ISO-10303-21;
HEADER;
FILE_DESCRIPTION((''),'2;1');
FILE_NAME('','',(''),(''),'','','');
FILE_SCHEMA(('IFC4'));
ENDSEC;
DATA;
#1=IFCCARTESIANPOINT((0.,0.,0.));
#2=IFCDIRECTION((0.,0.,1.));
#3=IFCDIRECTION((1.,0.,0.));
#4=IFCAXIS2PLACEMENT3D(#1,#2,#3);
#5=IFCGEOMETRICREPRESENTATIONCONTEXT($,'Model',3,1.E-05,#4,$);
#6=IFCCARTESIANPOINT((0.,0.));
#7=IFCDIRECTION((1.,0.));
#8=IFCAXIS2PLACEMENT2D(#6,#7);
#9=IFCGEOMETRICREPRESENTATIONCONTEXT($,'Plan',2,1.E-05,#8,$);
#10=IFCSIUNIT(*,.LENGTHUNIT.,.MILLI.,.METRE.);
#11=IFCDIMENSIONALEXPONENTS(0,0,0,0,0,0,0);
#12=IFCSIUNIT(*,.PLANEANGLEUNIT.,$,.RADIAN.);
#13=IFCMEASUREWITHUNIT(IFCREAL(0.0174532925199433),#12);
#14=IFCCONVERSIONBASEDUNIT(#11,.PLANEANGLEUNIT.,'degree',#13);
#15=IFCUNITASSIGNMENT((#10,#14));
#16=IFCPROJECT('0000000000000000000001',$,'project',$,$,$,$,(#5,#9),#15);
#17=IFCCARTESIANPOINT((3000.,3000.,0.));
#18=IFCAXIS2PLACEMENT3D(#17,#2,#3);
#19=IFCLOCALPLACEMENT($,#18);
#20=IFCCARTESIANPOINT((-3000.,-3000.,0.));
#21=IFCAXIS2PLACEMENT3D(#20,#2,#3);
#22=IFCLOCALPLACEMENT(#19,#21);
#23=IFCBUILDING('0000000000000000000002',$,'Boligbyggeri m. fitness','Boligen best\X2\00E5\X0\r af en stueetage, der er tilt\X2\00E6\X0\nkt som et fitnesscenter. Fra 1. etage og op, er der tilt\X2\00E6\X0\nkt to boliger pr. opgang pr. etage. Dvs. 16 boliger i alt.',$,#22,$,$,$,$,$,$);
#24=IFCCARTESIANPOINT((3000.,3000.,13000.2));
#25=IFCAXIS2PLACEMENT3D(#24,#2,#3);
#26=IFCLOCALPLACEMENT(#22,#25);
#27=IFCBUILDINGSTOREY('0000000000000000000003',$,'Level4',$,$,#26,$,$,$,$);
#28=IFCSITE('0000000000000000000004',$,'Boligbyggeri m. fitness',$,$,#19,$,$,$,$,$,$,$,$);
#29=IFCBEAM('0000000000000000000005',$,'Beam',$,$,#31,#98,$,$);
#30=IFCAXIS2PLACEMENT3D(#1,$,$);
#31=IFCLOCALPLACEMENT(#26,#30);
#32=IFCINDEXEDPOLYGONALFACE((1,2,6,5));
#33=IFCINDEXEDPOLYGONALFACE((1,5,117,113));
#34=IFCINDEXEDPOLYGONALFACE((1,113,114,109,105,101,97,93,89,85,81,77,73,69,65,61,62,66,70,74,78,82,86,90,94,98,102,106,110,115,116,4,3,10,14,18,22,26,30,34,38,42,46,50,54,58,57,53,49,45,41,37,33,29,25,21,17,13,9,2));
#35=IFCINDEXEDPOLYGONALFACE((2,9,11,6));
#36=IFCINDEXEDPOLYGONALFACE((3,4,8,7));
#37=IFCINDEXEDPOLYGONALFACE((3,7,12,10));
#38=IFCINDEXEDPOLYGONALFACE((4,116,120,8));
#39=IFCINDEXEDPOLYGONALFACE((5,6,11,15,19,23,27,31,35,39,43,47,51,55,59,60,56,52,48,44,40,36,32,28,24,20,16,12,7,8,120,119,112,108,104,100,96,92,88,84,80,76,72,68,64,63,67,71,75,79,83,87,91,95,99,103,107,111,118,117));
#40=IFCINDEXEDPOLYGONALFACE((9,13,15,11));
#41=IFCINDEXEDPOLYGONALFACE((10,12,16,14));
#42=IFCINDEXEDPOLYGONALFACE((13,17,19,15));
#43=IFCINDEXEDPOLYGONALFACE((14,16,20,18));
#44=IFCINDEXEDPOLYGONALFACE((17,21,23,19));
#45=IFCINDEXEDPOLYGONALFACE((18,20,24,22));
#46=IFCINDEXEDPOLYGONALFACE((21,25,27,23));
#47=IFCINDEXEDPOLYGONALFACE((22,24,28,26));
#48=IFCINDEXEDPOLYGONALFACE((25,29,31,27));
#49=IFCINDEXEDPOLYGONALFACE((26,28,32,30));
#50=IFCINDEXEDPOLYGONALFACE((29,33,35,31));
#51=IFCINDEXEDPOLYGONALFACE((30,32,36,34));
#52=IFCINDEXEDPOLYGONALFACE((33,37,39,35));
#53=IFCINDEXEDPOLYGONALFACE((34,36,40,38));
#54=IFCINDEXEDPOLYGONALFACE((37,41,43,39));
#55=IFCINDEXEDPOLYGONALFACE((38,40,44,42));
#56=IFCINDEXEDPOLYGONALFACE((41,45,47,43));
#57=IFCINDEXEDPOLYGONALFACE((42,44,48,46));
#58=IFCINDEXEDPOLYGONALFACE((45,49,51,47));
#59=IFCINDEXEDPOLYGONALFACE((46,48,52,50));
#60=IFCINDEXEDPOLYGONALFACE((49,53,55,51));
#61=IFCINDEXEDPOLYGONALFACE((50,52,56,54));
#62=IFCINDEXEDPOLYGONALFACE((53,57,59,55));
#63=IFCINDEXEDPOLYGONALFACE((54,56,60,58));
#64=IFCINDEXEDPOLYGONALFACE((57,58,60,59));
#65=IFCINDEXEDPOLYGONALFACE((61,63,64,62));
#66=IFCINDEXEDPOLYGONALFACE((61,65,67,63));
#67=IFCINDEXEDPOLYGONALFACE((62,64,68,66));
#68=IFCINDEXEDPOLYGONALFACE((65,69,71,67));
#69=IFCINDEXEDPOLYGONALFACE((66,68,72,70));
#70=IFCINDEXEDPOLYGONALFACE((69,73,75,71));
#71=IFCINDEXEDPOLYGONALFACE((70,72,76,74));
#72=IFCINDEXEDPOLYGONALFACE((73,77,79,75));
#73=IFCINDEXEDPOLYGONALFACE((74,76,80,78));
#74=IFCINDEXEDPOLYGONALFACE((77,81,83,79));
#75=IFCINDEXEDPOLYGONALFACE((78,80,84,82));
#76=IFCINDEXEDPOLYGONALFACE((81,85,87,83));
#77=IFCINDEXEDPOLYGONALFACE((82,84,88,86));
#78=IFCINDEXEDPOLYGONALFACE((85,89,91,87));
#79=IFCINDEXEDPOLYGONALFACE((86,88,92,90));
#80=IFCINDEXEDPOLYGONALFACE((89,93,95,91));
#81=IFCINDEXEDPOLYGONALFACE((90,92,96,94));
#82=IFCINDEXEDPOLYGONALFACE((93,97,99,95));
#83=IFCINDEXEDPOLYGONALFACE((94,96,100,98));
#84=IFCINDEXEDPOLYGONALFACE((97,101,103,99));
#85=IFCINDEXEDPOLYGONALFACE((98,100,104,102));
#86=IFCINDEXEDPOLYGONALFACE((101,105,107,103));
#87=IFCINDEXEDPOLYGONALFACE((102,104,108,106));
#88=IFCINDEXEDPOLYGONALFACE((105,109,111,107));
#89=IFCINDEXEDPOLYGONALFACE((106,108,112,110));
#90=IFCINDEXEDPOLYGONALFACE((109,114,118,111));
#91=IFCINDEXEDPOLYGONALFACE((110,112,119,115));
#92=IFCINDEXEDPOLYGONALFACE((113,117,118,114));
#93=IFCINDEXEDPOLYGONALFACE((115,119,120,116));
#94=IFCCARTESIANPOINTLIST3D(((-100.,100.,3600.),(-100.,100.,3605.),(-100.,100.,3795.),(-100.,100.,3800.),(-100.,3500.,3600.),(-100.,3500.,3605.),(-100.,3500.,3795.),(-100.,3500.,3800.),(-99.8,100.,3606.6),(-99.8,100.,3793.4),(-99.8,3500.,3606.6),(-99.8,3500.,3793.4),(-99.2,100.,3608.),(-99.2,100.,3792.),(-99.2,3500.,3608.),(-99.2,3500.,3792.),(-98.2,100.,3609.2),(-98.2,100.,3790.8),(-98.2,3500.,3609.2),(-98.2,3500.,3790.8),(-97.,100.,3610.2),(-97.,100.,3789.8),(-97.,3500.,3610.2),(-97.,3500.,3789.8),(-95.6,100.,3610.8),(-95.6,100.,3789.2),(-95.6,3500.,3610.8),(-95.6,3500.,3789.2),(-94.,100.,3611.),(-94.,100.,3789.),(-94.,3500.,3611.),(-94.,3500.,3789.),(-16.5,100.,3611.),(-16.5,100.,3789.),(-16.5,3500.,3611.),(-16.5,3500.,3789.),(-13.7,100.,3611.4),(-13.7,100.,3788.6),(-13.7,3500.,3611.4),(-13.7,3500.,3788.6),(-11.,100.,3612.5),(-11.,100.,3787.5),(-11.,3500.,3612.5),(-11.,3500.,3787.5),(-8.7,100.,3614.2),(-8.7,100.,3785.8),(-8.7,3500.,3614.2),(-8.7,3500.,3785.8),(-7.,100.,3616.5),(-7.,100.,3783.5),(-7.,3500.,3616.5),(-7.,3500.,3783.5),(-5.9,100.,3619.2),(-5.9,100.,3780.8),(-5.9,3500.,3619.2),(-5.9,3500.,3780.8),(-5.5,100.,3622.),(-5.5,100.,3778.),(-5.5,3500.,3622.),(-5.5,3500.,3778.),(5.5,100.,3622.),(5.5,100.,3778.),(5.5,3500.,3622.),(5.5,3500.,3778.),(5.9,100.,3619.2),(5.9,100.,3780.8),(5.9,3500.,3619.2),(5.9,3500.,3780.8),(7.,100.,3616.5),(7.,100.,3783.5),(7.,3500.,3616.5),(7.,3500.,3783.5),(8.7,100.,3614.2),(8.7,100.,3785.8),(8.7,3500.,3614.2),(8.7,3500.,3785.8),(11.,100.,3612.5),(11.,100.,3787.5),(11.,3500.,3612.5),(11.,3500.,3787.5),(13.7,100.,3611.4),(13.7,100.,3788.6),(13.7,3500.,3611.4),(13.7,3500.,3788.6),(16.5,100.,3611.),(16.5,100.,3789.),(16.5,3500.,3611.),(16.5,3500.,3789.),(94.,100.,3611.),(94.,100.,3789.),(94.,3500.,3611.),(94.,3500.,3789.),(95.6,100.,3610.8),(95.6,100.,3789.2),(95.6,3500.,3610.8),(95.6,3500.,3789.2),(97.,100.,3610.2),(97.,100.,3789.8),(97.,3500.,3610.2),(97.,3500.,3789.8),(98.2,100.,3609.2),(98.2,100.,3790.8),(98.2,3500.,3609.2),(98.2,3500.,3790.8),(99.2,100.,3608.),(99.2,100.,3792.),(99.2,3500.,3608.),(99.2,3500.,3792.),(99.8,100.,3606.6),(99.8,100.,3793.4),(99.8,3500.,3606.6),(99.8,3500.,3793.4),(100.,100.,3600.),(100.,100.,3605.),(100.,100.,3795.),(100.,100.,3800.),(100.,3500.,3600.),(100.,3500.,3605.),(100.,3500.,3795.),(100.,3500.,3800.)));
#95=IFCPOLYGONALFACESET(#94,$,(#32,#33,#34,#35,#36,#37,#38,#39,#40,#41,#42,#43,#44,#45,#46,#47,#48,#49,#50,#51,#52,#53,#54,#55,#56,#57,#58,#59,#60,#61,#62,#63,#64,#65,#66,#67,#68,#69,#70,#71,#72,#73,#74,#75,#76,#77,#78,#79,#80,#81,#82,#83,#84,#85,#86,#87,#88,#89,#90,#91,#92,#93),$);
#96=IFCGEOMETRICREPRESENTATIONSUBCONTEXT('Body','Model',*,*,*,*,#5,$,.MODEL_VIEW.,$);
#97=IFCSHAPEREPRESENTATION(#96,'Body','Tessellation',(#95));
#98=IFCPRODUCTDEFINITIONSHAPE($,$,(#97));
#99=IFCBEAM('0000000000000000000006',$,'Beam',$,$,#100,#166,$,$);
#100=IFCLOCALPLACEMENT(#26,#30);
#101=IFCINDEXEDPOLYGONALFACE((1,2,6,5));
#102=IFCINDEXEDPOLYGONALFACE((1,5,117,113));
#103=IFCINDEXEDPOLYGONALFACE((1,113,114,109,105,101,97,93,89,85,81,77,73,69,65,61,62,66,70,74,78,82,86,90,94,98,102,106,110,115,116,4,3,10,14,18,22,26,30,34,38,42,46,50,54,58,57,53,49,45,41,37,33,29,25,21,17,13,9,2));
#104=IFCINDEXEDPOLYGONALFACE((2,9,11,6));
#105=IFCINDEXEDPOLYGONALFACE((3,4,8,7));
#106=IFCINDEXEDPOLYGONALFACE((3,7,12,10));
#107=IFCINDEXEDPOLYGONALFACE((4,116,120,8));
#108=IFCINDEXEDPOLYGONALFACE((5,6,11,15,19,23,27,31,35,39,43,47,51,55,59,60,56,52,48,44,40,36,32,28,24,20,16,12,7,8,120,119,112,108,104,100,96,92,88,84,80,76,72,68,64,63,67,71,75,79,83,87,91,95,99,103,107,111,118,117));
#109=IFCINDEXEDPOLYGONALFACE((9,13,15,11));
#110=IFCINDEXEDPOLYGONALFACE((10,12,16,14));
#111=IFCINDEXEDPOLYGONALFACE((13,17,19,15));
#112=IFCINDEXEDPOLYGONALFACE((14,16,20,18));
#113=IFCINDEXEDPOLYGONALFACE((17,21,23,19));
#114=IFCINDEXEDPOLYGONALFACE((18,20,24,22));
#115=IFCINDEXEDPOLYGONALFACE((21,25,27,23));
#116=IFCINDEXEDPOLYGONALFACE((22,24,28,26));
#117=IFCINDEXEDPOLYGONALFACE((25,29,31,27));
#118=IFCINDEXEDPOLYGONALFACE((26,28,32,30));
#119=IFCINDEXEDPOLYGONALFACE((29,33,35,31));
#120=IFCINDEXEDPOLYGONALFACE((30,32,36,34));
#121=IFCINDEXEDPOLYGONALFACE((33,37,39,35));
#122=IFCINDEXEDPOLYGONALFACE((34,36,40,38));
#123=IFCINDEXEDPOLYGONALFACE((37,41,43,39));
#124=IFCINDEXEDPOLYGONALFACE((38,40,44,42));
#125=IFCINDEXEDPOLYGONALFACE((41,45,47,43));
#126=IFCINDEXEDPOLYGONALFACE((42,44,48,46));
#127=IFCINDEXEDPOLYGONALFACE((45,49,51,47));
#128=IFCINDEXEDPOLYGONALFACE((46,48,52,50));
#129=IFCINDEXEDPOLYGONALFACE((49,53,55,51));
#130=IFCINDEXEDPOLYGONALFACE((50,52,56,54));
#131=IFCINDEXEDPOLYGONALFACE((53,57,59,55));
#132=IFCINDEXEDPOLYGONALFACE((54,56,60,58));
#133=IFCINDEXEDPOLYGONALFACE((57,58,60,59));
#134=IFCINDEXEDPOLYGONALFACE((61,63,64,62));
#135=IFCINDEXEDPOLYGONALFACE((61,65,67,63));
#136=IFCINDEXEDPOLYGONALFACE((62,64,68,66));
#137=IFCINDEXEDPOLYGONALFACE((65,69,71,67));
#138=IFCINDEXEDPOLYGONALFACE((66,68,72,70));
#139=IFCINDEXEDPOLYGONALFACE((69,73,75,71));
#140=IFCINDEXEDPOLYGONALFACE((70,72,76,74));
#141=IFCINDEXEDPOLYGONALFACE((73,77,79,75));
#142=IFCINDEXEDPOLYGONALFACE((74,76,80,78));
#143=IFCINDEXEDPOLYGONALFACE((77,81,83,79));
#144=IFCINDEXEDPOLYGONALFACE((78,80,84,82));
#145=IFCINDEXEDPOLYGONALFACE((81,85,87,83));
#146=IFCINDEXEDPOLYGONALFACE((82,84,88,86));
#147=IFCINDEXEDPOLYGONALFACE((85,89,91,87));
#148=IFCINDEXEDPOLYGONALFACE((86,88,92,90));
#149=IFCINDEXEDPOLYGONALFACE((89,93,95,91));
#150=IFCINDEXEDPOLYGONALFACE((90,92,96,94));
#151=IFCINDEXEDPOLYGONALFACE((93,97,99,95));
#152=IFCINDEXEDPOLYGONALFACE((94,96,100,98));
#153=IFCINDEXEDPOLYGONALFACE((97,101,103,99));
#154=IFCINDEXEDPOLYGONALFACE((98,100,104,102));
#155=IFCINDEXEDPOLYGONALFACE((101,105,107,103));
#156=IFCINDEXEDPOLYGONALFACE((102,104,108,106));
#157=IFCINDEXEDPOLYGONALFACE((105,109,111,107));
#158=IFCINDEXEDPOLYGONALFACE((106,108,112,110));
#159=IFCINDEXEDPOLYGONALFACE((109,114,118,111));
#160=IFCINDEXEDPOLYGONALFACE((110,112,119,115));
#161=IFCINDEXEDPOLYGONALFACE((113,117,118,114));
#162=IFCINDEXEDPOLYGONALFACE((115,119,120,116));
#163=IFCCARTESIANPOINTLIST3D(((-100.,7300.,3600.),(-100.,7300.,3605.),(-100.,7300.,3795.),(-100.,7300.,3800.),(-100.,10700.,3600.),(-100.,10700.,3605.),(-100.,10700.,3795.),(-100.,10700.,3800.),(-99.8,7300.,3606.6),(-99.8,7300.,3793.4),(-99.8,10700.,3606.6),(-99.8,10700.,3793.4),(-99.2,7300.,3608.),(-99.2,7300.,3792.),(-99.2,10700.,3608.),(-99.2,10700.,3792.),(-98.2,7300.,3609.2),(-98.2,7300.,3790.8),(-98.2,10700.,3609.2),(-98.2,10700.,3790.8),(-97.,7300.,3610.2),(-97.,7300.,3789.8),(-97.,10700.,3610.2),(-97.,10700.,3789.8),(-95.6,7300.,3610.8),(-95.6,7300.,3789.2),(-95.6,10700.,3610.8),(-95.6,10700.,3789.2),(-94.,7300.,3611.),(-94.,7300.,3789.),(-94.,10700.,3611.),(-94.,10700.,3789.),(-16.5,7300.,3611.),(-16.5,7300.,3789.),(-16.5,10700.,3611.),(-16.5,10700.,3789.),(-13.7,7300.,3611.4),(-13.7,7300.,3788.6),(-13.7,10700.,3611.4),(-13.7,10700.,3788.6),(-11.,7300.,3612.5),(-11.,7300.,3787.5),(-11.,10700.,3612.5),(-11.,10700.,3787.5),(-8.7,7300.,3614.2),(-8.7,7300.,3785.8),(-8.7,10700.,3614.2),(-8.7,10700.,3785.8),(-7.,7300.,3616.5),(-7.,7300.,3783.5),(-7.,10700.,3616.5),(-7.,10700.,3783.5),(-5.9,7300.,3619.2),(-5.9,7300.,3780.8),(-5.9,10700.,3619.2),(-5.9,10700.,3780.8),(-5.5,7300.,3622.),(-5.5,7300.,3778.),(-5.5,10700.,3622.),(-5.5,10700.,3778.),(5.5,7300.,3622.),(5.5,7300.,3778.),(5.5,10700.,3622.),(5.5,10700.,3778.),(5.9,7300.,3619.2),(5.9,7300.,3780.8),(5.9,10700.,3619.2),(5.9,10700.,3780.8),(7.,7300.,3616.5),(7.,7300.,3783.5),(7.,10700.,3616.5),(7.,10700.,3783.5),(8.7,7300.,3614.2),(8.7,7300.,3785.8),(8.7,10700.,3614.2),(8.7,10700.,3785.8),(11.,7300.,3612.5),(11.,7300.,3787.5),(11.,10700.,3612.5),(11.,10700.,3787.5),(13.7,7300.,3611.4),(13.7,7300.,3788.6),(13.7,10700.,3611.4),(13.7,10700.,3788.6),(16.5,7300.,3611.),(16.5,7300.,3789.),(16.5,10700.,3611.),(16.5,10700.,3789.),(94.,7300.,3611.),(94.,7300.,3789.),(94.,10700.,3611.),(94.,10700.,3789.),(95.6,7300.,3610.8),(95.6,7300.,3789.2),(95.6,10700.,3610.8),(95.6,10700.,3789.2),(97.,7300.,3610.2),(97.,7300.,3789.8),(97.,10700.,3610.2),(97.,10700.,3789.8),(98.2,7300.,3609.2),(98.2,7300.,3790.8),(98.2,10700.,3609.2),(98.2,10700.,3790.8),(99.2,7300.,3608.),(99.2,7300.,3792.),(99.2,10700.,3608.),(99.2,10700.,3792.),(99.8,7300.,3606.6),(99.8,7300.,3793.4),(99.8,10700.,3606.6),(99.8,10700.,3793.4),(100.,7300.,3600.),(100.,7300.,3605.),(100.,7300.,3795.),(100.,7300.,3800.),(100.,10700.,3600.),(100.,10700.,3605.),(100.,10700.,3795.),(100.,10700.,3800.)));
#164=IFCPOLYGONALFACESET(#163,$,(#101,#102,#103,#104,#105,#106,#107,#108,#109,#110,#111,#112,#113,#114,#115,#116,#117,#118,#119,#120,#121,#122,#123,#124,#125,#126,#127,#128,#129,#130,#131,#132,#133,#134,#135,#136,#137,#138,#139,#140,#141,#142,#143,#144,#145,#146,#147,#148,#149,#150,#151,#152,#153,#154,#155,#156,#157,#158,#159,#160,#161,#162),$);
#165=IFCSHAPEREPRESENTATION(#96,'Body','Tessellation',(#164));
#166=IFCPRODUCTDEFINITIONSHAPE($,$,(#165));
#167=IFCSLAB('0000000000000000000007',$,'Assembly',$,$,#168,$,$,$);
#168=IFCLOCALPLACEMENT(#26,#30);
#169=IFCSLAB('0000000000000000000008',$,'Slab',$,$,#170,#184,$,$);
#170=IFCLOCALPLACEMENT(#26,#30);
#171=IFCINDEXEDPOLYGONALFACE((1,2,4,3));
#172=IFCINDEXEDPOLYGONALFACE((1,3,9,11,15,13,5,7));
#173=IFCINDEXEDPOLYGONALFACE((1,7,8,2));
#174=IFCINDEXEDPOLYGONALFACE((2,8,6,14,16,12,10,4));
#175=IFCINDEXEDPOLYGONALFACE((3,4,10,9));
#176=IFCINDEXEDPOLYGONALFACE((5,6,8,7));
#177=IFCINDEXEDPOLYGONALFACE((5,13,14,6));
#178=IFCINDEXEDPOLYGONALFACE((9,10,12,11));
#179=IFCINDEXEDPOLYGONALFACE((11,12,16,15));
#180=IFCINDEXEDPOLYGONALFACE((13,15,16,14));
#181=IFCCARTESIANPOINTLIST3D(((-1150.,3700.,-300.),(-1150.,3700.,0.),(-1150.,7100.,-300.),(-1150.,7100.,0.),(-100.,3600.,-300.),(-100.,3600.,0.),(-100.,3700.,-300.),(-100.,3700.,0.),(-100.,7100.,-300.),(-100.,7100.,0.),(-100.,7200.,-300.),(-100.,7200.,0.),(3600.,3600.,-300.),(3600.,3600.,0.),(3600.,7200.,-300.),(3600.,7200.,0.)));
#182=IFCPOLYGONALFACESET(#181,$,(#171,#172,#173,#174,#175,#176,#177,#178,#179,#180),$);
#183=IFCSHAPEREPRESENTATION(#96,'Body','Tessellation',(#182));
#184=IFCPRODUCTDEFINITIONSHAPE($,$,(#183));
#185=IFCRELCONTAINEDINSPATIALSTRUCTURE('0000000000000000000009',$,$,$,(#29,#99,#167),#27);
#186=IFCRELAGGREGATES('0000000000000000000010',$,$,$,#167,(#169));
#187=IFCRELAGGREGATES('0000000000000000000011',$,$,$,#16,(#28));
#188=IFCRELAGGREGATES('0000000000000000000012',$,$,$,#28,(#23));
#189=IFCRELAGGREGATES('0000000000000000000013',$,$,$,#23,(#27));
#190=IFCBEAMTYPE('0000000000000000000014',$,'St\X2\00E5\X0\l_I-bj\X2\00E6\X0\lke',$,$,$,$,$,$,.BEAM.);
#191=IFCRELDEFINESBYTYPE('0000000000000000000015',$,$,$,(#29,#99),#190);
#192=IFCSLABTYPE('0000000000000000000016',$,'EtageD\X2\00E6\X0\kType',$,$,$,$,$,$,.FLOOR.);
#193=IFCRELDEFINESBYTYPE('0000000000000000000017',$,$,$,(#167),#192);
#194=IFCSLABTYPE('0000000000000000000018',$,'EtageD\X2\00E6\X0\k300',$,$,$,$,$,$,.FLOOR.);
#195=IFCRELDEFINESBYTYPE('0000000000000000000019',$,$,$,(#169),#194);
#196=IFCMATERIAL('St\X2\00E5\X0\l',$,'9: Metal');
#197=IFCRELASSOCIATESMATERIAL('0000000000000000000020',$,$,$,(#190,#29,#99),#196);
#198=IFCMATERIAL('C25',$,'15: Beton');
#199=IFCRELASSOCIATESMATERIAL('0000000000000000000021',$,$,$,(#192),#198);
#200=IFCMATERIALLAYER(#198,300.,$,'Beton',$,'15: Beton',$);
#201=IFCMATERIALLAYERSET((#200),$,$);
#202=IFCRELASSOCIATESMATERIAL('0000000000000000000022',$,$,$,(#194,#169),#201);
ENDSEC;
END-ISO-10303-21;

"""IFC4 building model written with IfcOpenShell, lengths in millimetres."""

from ifc_helpers import new_model, entity, si_unit, converted_unit, frame, origin_with_axes, origin_2d_with_axis, place, context, subcontext, project, spatial, line, indexed_curve, i_section, outline, extrude, material, layer, layer_set, layer_usage, material_profile, profile_set, profile_usage, type_object, element, aggregate, save


model = new_model("IFC4")

# Units and contexts
model_context = context("Model", 3, precision=1e-05, world=origin_with_axes())
plan_context = context("Plan", 2, precision=1e-05, world=origin_2d_with_axis())
body_context = subcontext(model_context, "Body", "Model", "MODEL_VIEW")
ifc_project = project(units=[si_unit("LENGTHUNIT", "METRE", prefix="MILLI"), converted_unit("PLANEANGLEUNIT", "degree", entity("IfcReal", 0.0174532925199433), si_unit("PLANEANGLEUNIT", "RADIAN"), dimensions=[0, 0, 0, 0, 0, 0, 0])], contexts=[model_context, plan_context])

# Site, building, storey
site_placement = place(None, frame((3000.0, 3000.0, 0.0), z_axis=(0.0, 0.0, 1.0), x_axis=(1.0, 0.0, 0.0)))
site = spatial("IfcSite", under=ifc_project, at=site_placement, Name="Boligbyggeri m. fitness")
building_placement = place(site_placement, frame((-3000.0, -3000.0, 0.0), z_axis=(0.0, 0.0, 1.0), x_axis=(1.0, 0.0, 0.0)))
building = spatial("IfcBuilding", under=site, at=building_placement, Name="Boligbyggeri m. fitness", Description="Boligen består af en stueetage, der er tiltænkt som et fitnesscenter. Fra 1. etage og op, er der tiltænkt to boliger pr. opgang pr. etage. Dvs. 16 boliger i alt.")
storey_placement = place(building_placement, frame((3000.0, 3000.0, 13000.2), z_axis=(0.0, 0.0, 1.0), x_axis=(1.0, 0.0, 0.0)))
storey = spatial("IfcBuildingStorey", under=building, at=storey_placement, Name="Level4")

# Shared definitions
ifc_material_1 = material(Name="C25", Category="15: Beton")

# Beams
ifc_material_2 = material(Name="Stål", Category="9: Metal")
ifc_material_profile_1 = material_profile(ifc_material_2, i_section(OverallWidth=200.0, OverallDepth=200.0, WebThickness=11.0, FlangeThickness=11.0, FilletRadius=11.0, FlangeEdgeRadius=6.0), Name="Stål", Category="9: Metal")
ifc_profile_set_1 = profile_set([ifc_material_profile_1], Name="NY_I-Profil")
beam_type = type_object("IfcBeamType", Name="Stål_I-bjælke", PredefinedType="BEAM", material=ifc_profile_set_1)
ifc_profile_usage_1 = profile_usage(ifc_profile_set_1, cardinal=9)
beam_1_placement = place(storey_placement, frame((100.0, 100.0, 3800.0), z_axis=(0.0, 1.0, 0.0), x_axis=(-1.0, 0.0, 0.0)))
element("IfcBeam", 1, at=beam_1_placement, inside=storey, type_object=beam_type, material=ifc_profile_usage_1, Name="Beam", context=body_context, shape_type="SweptSolid", body=[
    extrude(i_section(OverallWidth=200.0, OverallDepth=200.0, WebThickness=11.0, FlangeThickness=11.0, FilletRadius=11.0, FlangeEdgeRadius=6.0), frame((100.0, -100.0, 0.0), z_axis=(0.0, 0.0, 1.0), x_axis=(1.0, 0.0, 0.0)), (0.0, 0.0, 1.0), 3400.0),
])
ifc_profile_usage_2 = profile_usage(ifc_profile_set_1, cardinal=9)
beam_2_placement = place(storey_placement, frame((100.0, 7300.0, 3800.0), z_axis=(0.0, 1.0, 0.0), x_axis=(-1.0, 0.0, 0.0)))
element("IfcBeam", 2, at=beam_2_placement, inside=storey, type_object=beam_type, material=ifc_profile_usage_2, Name="Beam", context=body_context, shape_type="SweptSolid", body=[
    extrude(i_section(OverallWidth=200.0, OverallDepth=200.0, WebThickness=11.0, FlangeThickness=11.0, FilletRadius=11.0, FlangeEdgeRadius=6.0), frame((100.0, -100.0, 0.0), z_axis=(0.0, 0.0, 1.0), x_axis=(1.0, 0.0, 0.0)), (0.0, 0.0, 1.0), 3400.0),
])

# Slabs
slab_type_1 = type_object("IfcSlabType", Name="EtageDækType", PredefinedType="FLOOR", material=ifc_material_1)
slab_1_placement = place(storey_placement, frame((25300.0, 3700.0, -12999.9), z_axis=(0.0, 0.0, 1.0), x_axis=(1.0, 0.0, 0.0)))
slab_1 = element("IfcSlab", 3, at=slab_1_placement, inside=storey, type_object=slab_type_1, Name="Assembly")
ifc_layer_1 = layer(ifc_material_1, 300.0, Name="Beton", Category="15: Beton")
ifc_layer_set_1 = layer_set([ifc_layer_1])
slab_type_2 = type_object("IfcSlabType", Name="EtageDæk300", PredefinedType="FLOOR", material=ifc_layer_set_1)
ifc_layer_usage_1 = layer_usage(ifc_layer_set_1, "AXIS3", "POSITIVE", 0.0)
slab_2_placement = place(slab_1_placement, frame((-25400.0, -100.0, 12699.9), z_axis=(0.0, 0.0, 1.0), x_axis=(1.0, 0.0, 0.0)))
slab_2 = element("IfcSlab", 4, at=slab_2_placement, type_object=slab_type_2, material=ifc_layer_usage_1, Name="Slab", context=body_context, shape_type="SweptSolid", body=[
    extrude(outline(indexed_curve([(3700.0, 3600.0), (3700.0, 0.0), (0.0, 0.0), (0.0, 3600.0), (-1050.0, 3500.0), (0.0, 3500.0), (0.0, 100.0), (-1050.0, 100.0)], segments=[line(8, 5), line(5, 6), line(6, 4), line(4, 1), line(1, 2), line(2, 3), line(3, 7), line(7, 8)], self_intersect=False)), None, (0.0, 0.0, 1.0), 300.0),
])
aggregate(slab_1, [slab_2])

save(model, "model.ifc")
